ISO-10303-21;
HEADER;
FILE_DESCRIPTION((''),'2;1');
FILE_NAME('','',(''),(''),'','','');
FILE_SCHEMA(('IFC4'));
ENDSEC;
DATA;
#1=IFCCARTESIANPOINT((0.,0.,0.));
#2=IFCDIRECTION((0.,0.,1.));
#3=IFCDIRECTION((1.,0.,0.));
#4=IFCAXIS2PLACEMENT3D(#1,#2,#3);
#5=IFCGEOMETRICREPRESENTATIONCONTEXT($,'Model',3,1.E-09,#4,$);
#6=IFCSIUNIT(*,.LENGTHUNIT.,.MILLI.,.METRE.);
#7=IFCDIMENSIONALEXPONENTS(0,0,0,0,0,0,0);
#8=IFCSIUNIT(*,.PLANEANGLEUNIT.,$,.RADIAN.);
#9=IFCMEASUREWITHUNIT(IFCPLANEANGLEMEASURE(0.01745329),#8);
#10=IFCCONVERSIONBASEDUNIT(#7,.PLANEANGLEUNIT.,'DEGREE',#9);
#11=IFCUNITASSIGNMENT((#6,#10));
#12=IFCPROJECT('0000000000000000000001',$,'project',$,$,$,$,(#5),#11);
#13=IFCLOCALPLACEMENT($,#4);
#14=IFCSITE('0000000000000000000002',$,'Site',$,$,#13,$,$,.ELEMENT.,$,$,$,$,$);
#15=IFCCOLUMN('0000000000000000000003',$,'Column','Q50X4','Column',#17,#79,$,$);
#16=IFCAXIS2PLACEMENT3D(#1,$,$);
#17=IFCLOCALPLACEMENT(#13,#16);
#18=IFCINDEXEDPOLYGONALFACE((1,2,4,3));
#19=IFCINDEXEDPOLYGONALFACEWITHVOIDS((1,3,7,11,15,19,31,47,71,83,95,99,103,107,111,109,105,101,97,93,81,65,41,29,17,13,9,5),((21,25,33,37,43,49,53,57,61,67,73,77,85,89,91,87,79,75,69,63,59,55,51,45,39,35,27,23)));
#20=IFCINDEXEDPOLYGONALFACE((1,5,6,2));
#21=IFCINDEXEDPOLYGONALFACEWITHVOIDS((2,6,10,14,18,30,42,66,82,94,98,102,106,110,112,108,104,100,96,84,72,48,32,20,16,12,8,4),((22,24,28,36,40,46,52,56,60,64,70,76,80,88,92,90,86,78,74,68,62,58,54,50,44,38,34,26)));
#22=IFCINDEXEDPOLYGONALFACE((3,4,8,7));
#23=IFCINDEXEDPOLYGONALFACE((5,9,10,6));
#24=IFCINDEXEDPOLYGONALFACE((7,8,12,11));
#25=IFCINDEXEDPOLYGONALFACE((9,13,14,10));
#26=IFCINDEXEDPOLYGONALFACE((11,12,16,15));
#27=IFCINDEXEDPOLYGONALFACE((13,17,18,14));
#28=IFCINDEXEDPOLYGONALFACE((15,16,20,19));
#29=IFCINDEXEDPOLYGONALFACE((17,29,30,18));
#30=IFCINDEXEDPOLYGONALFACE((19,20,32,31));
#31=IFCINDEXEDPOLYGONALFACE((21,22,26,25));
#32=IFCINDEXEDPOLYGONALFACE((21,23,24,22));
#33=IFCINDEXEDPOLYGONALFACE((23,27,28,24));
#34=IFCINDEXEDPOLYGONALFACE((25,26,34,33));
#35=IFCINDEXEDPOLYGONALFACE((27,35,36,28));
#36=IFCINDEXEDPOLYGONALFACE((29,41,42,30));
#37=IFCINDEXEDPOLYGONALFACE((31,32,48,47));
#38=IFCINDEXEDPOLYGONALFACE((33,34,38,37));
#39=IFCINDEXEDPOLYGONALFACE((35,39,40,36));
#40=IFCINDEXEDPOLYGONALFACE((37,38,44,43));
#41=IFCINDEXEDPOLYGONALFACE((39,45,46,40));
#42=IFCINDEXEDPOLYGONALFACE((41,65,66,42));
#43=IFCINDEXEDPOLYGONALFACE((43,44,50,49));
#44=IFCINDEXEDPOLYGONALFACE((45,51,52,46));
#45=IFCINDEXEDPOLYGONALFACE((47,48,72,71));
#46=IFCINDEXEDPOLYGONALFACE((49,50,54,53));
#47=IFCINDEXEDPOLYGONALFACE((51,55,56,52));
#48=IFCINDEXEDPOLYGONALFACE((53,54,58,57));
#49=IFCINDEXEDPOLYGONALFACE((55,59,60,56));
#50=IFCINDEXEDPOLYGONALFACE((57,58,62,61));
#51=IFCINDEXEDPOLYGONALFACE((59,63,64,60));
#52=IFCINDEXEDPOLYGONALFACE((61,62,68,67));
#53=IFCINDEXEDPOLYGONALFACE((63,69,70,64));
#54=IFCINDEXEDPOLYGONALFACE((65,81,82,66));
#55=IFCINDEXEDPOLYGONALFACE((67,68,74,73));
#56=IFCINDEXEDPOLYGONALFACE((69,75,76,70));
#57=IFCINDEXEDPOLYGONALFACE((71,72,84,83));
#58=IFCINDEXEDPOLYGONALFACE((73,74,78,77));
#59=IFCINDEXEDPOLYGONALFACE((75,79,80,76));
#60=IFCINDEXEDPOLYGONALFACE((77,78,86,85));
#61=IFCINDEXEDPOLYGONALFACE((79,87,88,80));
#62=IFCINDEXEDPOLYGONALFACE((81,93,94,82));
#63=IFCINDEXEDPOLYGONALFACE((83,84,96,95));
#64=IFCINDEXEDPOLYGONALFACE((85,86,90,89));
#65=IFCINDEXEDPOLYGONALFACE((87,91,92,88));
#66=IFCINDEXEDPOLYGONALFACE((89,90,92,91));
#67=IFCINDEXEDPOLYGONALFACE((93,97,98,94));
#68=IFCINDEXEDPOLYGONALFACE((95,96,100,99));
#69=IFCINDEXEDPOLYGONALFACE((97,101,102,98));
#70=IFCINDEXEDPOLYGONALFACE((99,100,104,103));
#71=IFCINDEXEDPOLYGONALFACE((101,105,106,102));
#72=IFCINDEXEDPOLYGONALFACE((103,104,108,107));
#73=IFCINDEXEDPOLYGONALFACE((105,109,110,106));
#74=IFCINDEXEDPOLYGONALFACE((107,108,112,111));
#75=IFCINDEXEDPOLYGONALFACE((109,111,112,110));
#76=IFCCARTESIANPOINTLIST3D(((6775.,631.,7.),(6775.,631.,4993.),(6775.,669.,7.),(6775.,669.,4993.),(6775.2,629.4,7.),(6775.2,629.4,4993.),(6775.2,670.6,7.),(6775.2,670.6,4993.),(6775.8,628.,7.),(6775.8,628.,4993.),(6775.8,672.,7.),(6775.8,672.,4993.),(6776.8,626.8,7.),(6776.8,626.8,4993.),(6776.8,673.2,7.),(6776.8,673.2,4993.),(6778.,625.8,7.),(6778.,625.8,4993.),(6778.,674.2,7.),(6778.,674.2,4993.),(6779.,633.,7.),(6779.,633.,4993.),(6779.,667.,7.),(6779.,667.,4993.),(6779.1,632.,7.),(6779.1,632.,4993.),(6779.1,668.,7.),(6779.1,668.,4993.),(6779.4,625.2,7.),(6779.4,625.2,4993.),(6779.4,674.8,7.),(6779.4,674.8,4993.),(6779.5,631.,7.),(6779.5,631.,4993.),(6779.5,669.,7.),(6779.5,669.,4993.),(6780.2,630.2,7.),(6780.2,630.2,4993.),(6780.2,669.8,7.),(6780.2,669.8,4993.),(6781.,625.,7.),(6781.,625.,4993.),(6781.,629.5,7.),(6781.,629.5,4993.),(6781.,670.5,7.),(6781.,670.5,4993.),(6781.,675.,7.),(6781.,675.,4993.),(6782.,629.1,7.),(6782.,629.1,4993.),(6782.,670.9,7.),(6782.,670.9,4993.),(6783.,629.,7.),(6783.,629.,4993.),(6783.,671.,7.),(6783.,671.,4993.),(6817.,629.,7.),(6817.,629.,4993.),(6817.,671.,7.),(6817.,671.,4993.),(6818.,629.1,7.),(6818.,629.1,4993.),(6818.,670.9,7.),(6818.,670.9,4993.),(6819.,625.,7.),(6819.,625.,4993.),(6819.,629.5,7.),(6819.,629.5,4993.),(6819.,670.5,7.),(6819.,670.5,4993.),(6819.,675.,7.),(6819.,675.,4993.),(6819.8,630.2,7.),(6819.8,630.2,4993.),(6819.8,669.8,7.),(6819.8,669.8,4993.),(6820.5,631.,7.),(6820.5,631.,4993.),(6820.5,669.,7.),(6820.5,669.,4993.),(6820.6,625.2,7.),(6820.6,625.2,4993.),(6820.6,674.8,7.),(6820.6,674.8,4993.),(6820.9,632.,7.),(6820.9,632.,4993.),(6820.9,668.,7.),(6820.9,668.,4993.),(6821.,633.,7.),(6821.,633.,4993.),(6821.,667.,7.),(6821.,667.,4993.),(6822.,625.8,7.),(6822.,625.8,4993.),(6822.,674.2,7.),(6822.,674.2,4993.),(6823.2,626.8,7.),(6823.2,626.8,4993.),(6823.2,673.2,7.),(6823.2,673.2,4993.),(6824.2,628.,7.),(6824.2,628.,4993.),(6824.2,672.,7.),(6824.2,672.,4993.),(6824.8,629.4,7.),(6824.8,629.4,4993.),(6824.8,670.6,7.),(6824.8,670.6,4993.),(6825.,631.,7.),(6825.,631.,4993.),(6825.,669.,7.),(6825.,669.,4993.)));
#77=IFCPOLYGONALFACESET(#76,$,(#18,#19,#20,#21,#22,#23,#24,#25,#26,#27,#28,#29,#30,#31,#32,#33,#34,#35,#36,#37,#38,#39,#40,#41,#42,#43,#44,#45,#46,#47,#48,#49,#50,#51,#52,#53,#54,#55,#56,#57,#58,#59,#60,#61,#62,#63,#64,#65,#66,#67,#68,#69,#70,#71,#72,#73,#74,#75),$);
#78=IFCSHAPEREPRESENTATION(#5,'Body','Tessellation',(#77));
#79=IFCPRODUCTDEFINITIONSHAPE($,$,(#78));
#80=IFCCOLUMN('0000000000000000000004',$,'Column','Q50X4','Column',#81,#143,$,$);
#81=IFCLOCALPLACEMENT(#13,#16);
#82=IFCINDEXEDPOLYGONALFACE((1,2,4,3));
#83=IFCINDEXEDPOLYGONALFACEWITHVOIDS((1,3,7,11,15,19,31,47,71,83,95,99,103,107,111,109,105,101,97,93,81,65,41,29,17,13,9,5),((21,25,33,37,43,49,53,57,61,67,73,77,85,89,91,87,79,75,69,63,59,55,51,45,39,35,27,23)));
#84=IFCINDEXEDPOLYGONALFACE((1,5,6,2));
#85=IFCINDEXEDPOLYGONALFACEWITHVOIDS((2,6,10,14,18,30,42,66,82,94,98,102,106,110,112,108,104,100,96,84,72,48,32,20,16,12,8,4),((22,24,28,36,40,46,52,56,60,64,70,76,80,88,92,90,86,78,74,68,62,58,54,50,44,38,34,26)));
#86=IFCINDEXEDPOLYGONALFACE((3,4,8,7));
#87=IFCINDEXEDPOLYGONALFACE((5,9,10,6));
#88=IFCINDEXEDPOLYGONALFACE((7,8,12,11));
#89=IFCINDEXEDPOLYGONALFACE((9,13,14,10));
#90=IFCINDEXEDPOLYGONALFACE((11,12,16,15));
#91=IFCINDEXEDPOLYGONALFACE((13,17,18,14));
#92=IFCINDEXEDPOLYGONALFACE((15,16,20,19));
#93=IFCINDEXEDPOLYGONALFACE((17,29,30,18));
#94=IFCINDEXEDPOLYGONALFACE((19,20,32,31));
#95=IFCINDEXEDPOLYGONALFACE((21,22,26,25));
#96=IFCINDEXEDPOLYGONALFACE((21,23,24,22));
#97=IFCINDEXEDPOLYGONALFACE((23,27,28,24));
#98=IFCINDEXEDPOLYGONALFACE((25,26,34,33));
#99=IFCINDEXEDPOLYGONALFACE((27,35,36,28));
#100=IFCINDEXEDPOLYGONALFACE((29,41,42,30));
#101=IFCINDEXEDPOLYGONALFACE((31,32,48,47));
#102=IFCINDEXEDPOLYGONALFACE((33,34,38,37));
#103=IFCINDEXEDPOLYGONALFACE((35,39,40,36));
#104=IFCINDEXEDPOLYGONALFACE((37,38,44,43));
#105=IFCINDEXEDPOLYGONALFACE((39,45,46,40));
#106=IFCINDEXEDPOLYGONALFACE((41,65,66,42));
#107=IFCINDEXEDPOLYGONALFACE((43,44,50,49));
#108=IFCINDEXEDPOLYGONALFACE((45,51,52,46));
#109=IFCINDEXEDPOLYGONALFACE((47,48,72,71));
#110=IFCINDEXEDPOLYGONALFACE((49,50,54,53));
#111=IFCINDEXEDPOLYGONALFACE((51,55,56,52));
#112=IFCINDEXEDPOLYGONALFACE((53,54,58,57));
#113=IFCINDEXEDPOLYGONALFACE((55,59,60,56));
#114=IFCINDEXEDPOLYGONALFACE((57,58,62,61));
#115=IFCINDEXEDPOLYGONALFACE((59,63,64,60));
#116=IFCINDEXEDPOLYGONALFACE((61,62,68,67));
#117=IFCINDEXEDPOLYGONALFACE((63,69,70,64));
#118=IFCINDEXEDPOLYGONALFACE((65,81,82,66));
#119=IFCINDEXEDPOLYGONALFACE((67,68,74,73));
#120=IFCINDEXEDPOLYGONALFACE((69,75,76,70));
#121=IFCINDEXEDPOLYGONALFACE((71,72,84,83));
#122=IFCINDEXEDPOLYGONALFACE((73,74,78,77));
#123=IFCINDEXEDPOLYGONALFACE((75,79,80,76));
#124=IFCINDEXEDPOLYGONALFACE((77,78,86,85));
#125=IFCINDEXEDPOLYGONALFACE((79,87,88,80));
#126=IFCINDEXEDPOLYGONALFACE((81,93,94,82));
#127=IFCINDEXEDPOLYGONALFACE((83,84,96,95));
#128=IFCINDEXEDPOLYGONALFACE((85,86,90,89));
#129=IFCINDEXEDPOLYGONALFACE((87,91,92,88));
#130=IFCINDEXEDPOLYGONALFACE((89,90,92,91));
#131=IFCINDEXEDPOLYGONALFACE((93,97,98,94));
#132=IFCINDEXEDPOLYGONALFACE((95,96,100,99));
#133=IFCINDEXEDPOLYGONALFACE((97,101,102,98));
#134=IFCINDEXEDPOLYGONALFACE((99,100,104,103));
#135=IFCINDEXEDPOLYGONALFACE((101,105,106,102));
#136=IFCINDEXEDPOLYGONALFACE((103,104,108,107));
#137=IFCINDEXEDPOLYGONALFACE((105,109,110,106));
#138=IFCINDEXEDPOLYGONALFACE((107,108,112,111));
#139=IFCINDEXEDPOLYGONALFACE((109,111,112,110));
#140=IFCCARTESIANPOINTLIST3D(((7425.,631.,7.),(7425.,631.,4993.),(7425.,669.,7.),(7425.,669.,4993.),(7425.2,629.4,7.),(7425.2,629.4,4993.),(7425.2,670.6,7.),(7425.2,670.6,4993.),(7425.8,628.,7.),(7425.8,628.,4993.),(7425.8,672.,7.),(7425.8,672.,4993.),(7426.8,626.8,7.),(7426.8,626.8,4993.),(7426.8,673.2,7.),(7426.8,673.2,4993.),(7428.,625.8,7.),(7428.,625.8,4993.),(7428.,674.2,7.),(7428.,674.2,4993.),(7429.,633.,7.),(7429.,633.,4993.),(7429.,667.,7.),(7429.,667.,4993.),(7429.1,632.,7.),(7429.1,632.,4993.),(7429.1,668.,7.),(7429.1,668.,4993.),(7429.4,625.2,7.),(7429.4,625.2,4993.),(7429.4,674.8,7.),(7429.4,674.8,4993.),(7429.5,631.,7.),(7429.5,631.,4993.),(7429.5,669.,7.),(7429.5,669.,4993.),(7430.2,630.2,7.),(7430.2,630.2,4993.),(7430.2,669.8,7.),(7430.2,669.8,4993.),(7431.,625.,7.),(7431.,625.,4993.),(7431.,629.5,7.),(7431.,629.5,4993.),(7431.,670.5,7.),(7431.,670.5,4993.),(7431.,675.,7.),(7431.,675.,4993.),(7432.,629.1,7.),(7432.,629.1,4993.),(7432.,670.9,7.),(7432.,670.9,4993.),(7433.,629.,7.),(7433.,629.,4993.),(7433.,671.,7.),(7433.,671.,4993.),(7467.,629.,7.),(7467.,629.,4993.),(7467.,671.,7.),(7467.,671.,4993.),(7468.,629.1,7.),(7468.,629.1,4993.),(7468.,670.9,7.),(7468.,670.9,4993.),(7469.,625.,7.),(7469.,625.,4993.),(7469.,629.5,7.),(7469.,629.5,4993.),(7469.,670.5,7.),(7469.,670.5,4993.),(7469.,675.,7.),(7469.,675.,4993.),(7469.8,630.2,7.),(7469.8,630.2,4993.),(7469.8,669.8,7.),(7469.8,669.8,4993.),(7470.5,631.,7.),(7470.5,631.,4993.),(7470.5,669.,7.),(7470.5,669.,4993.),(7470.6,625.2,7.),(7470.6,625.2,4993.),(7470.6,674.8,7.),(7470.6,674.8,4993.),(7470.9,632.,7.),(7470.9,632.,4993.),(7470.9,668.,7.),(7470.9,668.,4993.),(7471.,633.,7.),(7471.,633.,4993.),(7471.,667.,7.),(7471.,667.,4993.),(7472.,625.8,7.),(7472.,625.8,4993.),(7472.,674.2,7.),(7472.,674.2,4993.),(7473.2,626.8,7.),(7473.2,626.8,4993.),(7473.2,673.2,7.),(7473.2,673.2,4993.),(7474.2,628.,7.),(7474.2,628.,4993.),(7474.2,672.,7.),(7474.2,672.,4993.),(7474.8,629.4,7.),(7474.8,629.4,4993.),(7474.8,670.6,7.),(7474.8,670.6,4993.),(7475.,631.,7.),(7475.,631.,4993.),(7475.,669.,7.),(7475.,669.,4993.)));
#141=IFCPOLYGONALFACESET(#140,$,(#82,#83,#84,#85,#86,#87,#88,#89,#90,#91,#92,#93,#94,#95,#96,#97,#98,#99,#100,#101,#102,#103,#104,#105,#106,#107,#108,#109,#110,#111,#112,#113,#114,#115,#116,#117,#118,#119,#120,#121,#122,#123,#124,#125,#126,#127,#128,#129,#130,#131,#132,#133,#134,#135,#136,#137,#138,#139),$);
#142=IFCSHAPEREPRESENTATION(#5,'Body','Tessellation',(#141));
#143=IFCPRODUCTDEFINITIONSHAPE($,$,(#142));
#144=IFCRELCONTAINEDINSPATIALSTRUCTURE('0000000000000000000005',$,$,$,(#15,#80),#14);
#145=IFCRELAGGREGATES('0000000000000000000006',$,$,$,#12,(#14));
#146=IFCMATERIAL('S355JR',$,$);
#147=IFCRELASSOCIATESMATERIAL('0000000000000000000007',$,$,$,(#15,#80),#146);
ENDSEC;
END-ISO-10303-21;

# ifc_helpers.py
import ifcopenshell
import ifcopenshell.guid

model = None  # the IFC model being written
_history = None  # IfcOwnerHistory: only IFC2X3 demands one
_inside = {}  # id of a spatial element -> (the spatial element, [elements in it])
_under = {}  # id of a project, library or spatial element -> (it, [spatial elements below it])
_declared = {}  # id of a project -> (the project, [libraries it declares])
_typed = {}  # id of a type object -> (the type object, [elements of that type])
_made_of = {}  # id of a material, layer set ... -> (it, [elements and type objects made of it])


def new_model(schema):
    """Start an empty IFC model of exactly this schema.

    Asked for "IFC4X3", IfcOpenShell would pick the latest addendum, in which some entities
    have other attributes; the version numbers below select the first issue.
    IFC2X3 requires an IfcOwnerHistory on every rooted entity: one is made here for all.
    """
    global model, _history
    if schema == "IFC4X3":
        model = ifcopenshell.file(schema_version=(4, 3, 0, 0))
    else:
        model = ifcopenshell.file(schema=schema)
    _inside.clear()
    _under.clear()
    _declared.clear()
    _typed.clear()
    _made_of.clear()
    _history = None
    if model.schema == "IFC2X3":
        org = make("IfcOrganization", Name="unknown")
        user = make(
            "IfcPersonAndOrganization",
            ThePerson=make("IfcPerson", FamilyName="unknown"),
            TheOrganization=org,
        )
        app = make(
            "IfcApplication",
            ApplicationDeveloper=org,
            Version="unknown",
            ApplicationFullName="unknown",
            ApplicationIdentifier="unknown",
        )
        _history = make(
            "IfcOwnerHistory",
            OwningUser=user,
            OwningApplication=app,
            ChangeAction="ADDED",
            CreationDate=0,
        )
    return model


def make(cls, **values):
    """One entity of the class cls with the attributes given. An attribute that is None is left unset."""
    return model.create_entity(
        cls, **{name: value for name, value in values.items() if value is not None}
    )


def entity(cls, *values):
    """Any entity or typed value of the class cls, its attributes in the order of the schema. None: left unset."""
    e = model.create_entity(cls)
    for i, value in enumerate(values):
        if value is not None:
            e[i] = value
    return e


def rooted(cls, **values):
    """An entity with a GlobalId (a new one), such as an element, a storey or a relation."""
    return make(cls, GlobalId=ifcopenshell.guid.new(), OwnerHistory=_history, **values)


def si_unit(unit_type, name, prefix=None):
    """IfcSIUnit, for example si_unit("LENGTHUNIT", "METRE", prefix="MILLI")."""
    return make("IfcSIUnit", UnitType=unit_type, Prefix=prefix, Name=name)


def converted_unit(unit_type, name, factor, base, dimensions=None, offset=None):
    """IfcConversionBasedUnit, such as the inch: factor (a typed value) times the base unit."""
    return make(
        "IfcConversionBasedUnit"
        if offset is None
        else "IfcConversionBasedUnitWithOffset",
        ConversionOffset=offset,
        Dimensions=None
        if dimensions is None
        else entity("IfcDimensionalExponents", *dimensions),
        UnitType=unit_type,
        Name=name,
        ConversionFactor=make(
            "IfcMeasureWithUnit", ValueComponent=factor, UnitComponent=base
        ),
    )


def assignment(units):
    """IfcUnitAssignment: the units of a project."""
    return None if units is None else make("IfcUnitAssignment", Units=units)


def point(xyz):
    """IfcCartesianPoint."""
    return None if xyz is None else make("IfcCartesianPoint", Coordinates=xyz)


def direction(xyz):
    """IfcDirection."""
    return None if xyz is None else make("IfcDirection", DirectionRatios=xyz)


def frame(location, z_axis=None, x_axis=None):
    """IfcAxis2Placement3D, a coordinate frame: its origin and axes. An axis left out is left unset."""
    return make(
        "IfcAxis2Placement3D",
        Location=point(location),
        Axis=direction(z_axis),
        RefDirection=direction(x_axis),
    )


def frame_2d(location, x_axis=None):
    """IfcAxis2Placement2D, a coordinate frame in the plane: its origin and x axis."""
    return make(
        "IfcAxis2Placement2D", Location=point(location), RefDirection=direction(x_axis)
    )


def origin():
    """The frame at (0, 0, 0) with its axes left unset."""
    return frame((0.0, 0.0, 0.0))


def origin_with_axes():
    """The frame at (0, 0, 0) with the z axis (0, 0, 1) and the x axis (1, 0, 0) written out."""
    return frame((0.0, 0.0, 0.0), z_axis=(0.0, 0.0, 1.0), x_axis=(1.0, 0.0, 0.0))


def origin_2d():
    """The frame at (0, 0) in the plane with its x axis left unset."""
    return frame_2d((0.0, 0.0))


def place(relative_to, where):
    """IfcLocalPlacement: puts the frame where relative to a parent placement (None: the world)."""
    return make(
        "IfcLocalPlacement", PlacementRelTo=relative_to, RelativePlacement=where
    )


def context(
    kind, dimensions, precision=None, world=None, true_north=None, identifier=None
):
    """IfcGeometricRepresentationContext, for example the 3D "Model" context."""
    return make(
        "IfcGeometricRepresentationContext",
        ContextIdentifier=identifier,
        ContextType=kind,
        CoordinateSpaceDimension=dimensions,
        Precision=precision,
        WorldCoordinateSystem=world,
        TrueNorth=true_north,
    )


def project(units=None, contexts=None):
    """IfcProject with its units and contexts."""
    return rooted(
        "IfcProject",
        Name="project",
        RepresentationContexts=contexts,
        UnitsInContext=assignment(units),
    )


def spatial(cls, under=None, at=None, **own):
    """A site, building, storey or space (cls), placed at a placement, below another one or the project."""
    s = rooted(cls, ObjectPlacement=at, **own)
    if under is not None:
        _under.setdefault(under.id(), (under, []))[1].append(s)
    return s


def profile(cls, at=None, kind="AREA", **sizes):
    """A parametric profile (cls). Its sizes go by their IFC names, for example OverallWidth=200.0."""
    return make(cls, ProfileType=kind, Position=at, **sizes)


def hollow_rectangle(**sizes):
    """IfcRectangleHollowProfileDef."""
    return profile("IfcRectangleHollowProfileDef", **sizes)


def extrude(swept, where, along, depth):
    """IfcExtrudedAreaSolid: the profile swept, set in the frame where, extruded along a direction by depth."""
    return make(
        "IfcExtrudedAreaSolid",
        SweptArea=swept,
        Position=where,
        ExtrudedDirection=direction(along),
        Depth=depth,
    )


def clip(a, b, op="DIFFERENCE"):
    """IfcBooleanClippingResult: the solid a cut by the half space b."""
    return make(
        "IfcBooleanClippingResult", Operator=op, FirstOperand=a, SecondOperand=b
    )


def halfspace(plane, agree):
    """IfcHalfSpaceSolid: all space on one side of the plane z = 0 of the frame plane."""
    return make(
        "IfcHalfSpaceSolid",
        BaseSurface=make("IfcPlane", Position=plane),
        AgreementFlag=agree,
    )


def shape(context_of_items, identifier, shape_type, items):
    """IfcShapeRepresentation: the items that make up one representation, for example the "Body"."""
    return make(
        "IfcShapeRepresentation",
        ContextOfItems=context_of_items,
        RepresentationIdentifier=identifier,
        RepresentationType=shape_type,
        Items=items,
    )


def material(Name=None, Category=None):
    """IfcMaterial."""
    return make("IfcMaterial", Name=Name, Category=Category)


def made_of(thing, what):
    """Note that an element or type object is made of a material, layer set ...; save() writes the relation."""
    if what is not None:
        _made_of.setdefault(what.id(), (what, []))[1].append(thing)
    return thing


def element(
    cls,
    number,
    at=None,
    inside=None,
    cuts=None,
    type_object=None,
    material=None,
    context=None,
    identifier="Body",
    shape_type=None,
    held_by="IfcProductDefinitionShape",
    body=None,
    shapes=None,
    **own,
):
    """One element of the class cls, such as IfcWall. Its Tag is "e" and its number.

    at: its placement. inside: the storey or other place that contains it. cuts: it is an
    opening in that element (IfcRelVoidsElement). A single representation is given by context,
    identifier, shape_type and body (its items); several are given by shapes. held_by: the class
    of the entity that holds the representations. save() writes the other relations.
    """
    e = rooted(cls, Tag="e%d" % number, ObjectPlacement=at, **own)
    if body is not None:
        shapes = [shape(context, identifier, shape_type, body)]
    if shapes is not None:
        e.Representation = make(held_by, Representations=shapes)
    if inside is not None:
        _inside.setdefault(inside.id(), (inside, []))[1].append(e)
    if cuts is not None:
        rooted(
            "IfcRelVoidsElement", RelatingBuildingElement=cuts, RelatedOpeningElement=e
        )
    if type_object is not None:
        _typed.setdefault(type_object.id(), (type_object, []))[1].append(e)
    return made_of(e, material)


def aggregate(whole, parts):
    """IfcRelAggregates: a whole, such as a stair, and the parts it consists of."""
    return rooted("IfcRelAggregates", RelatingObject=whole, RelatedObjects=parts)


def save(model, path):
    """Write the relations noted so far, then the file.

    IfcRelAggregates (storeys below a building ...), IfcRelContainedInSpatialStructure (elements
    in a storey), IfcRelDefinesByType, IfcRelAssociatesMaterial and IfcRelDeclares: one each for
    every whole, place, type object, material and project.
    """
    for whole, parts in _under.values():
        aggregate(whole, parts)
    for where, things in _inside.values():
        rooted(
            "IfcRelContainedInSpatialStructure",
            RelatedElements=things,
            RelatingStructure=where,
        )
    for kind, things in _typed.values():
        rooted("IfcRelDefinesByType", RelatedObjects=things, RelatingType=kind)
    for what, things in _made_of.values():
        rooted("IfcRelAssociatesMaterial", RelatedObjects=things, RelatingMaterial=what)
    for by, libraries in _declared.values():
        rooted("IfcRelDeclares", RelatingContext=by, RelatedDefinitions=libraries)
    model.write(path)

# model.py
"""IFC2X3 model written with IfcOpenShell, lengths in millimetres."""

from ifc_helpers import new_model, entity, si_unit, converted_unit, frame, origin, origin_with_axes, origin_2d, place, context, project, spatial, hollow_rectangle, extrude, clip, halfspace, material, element, save


model = new_model("IFC2X3")

# Units and contexts
model_context = context("Model", 3, precision=1e-09, world=origin_with_axes())
ifc_project = project(units=[si_unit("LENGTHUNIT", "METRE", prefix="MILLI"), converted_unit("PLANEANGLEUNIT", "DEGREE", entity("IfcPlaneAngleMeasure", 0.01745329), si_unit("PLANEANGLEUNIT", "RADIAN"), dimensions=[0, 0, 0, 0, 0, 0, 0])], contexts=[model_context])

# Site
site_placement = place(None, origin_with_axes())
site = spatial("IfcSite", under=ifc_project, at=site_placement, Name="Site", CompositionType="ELEMENT")

# Columns
ifc_material = material(Name="S355JR")
column_1_placement = place(None, frame((6800.0, 650.0, -35.4), z_axis=(0.0, 0.0, -1.0), x_axis=(-1.0, 0.0, 0.0)))
element("IfcColumn", 1, at=column_1_placement, inside=site, material=ifc_material, Name="Column", Description="Q50X4", ObjectType="Column", context=model_context, shape_type="Clipping", body=[
    clip(clip(extrude(hollow_rectangle(XDim=50.0, YDim=50.0, WallThickness=4.0, InnerFilletRadius=4.0, OuterFilletRadius=6.0, at=origin_2d()), origin(), (0.0, 0.0, -1.0), 5070.7), halfspace(frame((6800.0, -650.0, -5028.4), z_axis=(0.0, 0.0, 1.0), x_axis=(1.0, 0.0, 0.0)), True)), halfspace(frame((6800.0, -650.0, -42.4), z_axis=(0.0, 0.0, -1.0), x_axis=(-1.0, 0.0, 0.0)), True)),
])
column_2_placement = place(None, frame((7450.0, 650.0, -35.4), z_axis=(0.0, 0.0, -1.0), x_axis=(-1.0, 0.0, 0.0)))
element("IfcColumn", 2, at=column_2_placement, inside=site, material=ifc_material, Name="Column", Description="Q50X4", ObjectType="Column", context=model_context, shape_type="Clipping", body=[
    clip(clip(extrude(hollow_rectangle(XDim=50.0, YDim=50.0, WallThickness=4.0, InnerFilletRadius=4.0, OuterFilletRadius=6.0, at=origin_2d()), origin(), (0.0, 0.0, -1.0), 5070.7), halfspace(frame((7450.0, -650.0, -5028.4), z_axis=(0.0, 0.0, 1.0), x_axis=(1.0, 0.0, 0.0)), True)), halfspace(frame((7450.0, -650.0, -42.4), z_axis=(0.0, 0.0, -1.0), x_axis=(-1.0, 0.0, 0.0)), True)),
])

save(model, "model.ifc")
